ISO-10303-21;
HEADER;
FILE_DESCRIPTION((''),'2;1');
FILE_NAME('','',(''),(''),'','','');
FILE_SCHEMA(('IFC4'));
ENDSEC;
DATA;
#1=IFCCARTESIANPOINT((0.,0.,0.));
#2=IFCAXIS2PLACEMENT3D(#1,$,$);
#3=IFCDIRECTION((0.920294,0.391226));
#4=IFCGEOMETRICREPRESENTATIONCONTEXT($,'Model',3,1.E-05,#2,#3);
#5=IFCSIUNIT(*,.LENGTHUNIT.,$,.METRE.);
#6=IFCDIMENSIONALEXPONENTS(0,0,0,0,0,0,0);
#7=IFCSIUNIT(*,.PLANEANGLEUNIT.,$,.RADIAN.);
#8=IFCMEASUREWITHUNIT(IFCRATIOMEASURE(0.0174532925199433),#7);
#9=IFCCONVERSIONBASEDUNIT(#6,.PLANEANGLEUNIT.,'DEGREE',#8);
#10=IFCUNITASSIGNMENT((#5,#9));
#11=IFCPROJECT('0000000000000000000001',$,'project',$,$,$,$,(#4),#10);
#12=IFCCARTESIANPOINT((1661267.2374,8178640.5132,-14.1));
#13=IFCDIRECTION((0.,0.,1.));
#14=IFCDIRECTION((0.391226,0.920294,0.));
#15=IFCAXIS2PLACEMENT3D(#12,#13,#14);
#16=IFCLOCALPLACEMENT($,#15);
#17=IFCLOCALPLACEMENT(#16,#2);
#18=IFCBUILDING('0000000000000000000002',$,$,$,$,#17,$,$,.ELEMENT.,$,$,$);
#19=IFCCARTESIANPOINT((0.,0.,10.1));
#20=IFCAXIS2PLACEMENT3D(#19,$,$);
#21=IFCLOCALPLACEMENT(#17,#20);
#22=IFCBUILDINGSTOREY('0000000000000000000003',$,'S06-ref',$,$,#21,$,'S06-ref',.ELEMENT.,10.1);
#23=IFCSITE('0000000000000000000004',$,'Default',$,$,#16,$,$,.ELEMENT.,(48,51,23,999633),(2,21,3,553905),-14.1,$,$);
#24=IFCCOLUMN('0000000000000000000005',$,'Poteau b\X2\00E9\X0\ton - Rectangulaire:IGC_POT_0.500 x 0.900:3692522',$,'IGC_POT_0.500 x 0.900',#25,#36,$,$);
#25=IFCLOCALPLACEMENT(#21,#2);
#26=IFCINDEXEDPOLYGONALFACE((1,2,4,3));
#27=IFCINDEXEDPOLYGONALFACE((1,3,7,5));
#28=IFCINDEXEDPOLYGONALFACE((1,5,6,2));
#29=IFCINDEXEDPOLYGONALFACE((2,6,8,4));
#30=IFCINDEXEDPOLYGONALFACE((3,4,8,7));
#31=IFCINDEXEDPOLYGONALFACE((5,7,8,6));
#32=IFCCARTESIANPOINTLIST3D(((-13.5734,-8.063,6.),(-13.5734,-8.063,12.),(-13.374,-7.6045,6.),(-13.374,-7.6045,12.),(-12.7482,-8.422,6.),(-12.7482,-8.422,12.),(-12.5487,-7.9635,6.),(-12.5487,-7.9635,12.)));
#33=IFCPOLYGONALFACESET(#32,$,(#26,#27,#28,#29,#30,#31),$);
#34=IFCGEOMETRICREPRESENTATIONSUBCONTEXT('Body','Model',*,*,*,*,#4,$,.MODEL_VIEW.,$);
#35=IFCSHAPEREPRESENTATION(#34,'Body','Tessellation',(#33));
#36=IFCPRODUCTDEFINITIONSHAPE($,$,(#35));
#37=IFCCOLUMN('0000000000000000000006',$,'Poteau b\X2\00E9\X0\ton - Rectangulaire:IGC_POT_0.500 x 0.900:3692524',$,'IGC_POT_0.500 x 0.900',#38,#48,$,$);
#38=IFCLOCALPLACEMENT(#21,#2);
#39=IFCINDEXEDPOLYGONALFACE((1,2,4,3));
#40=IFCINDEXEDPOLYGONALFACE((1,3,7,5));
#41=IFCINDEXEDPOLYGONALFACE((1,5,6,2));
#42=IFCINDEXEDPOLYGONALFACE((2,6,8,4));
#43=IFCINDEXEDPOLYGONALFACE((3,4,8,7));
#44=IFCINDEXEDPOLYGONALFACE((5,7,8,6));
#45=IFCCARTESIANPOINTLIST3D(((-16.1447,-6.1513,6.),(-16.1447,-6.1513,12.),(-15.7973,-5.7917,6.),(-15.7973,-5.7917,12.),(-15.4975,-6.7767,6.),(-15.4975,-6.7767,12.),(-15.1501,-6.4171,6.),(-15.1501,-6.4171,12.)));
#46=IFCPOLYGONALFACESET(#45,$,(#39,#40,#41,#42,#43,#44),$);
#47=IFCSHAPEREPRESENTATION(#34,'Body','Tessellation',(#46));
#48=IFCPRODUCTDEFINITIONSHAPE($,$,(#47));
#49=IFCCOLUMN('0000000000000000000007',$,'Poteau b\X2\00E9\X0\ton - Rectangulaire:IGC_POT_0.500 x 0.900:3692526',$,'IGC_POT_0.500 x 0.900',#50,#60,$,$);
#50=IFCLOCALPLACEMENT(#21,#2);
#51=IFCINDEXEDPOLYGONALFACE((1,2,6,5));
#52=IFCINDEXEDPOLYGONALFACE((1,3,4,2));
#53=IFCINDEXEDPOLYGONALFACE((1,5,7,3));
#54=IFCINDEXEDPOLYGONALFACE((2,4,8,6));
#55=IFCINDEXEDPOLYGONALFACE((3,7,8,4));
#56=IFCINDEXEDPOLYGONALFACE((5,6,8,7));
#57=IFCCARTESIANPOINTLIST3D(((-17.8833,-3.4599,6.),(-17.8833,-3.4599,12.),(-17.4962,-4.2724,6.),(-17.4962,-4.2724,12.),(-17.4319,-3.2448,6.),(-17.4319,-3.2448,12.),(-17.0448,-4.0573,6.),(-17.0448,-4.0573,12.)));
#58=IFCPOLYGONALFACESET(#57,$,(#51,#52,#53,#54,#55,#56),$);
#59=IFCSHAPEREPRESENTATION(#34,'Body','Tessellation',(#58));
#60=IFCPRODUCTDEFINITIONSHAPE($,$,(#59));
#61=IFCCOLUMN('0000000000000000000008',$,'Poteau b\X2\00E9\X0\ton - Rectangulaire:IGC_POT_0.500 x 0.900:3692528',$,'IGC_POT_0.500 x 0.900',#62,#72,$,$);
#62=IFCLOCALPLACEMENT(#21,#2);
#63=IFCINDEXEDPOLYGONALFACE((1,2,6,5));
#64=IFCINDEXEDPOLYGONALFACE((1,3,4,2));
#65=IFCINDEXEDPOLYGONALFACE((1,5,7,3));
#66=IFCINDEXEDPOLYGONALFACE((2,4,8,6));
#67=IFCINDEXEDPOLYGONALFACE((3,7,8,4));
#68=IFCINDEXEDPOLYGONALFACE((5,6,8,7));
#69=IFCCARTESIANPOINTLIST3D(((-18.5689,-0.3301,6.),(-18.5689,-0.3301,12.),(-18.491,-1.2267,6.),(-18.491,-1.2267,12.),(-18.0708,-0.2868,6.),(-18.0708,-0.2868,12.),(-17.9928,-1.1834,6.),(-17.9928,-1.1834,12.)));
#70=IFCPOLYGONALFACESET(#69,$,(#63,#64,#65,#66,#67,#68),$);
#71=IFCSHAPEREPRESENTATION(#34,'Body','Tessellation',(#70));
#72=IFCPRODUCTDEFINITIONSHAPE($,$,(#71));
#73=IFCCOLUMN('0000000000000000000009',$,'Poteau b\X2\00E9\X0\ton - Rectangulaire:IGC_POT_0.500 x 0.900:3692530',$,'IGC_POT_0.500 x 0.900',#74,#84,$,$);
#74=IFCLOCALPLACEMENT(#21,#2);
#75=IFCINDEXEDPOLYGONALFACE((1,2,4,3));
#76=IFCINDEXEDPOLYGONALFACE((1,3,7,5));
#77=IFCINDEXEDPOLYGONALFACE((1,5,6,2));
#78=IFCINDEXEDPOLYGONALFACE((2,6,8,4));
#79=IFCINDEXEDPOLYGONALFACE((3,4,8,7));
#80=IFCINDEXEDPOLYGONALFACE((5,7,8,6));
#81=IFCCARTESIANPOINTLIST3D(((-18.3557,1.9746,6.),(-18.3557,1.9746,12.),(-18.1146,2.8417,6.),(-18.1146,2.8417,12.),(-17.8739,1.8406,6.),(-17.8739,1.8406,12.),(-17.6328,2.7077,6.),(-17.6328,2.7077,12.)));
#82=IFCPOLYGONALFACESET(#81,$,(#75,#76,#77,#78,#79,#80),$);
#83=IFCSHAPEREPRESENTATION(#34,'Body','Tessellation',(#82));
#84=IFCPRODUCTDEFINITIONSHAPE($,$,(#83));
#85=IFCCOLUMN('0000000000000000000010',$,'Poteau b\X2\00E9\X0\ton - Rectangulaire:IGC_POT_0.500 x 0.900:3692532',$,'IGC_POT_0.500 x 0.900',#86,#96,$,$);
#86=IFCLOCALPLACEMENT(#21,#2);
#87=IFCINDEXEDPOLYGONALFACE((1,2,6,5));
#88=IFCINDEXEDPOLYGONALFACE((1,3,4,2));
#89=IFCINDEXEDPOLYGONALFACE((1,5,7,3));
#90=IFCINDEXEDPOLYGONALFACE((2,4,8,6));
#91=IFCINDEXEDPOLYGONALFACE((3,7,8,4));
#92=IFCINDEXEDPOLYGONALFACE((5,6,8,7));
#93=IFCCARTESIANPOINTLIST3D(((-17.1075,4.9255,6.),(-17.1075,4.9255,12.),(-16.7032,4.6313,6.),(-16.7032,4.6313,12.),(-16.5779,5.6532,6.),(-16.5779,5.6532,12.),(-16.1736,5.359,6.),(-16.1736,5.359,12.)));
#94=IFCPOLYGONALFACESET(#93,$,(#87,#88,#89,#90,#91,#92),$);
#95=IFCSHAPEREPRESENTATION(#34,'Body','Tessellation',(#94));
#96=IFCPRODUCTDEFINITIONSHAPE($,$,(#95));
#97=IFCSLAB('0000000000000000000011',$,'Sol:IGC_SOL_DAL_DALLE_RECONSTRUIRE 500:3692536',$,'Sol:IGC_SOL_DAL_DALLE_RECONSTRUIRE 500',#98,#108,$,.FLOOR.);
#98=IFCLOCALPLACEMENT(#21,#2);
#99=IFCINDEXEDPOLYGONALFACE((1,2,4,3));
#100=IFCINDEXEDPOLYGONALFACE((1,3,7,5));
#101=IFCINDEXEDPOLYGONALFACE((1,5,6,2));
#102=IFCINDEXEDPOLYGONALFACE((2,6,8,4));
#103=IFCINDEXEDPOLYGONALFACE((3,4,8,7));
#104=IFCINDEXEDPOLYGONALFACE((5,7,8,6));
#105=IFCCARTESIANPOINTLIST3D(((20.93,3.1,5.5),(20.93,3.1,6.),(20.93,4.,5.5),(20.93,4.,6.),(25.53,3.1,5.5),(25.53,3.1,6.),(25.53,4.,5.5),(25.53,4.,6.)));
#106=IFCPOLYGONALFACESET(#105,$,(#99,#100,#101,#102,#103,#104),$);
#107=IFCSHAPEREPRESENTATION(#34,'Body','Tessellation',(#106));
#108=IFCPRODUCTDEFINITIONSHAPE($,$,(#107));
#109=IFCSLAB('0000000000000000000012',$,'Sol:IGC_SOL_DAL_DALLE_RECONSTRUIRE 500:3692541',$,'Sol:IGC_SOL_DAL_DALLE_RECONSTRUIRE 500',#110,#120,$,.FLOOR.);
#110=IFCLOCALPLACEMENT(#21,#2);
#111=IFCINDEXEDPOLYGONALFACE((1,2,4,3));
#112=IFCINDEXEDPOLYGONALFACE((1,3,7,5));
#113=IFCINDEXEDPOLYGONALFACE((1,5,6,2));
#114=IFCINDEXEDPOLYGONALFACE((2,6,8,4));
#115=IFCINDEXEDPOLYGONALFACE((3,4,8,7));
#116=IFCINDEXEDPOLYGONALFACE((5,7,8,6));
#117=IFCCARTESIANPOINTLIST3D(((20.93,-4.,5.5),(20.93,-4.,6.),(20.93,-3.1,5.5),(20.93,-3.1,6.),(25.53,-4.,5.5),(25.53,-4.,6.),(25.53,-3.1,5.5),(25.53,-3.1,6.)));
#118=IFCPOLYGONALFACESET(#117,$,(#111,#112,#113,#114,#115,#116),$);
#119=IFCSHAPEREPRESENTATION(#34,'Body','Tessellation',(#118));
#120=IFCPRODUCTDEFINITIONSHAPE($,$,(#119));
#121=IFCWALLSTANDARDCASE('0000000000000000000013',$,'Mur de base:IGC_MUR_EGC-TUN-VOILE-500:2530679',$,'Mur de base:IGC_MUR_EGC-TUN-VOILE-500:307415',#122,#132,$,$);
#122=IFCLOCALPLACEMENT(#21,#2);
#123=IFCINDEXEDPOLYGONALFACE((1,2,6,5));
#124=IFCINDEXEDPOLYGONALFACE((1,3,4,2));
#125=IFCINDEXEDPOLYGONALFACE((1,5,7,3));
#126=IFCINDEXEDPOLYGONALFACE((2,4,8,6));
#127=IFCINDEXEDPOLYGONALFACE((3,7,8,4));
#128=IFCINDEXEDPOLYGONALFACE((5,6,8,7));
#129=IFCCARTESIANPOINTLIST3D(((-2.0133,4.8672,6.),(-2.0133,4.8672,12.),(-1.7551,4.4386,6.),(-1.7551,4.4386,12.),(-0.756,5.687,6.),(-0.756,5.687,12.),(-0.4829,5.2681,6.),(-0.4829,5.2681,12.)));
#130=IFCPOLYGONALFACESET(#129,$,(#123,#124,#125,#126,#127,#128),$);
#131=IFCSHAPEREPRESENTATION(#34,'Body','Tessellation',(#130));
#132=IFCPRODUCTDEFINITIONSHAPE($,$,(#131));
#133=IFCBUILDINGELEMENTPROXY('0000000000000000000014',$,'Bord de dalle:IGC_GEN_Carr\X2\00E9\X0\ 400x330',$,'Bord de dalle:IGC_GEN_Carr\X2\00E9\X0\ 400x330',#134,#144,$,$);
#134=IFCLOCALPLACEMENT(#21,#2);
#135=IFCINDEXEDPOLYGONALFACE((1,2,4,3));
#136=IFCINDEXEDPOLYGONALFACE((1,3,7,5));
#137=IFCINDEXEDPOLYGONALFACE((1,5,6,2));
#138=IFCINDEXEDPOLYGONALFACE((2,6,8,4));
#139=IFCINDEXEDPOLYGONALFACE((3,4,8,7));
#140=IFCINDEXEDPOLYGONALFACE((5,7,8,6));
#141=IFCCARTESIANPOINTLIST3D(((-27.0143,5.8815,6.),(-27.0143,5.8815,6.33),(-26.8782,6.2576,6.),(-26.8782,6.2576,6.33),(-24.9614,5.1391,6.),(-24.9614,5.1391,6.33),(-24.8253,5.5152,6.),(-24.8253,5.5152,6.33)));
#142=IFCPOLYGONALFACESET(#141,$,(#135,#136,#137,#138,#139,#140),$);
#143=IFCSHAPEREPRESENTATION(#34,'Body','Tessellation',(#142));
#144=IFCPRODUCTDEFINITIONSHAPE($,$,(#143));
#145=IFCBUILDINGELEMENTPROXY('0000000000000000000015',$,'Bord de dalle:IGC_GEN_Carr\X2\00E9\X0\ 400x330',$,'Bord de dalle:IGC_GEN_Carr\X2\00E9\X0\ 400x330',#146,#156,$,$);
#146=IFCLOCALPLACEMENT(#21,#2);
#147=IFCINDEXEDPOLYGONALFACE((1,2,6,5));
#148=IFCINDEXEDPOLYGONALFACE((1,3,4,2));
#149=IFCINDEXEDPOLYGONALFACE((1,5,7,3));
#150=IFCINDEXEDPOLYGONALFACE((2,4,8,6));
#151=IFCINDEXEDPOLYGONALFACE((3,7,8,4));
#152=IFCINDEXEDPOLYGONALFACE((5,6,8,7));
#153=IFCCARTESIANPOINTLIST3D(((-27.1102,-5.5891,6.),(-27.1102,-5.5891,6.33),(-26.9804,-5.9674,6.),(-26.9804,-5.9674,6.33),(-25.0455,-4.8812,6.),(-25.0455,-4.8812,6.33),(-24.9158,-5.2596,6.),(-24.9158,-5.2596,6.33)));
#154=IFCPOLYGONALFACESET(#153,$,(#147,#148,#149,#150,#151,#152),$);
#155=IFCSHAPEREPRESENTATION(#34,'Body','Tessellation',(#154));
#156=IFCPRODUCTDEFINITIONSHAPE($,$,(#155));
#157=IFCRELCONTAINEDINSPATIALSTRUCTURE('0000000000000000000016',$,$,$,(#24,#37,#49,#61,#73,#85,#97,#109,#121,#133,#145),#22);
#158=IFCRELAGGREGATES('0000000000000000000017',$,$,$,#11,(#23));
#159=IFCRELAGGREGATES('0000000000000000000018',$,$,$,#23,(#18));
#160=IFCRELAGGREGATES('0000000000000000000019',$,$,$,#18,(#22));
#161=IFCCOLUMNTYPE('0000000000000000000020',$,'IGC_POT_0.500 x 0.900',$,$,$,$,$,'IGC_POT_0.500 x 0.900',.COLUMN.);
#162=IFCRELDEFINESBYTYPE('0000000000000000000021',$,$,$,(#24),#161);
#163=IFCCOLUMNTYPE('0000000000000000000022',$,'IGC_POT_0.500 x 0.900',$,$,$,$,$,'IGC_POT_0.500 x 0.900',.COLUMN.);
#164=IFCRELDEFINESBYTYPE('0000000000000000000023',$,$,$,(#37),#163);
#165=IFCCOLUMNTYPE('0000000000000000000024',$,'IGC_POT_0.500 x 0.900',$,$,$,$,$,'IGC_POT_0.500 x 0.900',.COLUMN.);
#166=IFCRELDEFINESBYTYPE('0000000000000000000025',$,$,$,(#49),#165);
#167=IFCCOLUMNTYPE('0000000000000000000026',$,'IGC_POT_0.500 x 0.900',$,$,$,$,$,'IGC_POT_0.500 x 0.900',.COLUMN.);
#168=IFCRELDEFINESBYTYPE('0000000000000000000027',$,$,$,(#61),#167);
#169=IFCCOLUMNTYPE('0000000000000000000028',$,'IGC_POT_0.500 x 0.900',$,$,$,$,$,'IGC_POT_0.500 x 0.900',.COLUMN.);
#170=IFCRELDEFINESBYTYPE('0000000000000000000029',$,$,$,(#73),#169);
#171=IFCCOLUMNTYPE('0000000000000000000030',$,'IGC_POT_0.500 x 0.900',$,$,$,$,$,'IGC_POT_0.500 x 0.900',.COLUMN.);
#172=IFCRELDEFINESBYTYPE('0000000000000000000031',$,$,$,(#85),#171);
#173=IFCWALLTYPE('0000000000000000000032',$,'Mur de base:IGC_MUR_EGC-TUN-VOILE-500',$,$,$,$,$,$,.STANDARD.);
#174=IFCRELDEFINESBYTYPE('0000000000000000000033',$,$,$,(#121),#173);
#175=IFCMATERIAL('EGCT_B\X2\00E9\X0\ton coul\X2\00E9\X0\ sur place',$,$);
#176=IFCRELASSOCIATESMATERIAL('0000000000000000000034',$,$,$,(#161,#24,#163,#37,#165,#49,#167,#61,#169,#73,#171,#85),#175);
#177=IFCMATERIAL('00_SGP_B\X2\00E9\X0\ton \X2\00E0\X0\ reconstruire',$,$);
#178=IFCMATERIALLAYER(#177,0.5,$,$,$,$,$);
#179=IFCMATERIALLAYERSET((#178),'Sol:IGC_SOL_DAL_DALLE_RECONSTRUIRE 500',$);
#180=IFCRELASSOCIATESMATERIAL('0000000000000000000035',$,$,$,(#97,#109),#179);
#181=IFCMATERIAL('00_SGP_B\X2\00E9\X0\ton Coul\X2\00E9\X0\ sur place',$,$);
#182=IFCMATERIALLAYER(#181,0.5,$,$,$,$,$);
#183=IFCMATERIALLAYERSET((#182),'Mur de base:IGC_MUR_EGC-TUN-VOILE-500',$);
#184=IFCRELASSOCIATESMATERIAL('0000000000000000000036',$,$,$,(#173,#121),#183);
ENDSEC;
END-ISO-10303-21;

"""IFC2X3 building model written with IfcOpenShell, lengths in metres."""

from ifc_helpers import new_model, entity, si_unit, converted_unit, direction, frame, frame_2d, origin, origin_2d_with_axis, place, context, subcontext, project, spatial, polyline, rectangle, extrude, clip, bounded_halfspace, source, transform, mapped, material, layer, layer_set, layer_usage, type_object, type_shapes, element, save


model = new_model("IFC2X3")

# Units and contexts
model_context = context("Model", 3, precision=1e-05, world=origin(), true_north=direction((0.920294, 0.391226)))
body_context = subcontext(model_context, "Body", "Model", "MODEL_VIEW")
ifc_project = project(units=[si_unit("LENGTHUNIT", "METRE"), converted_unit("PLANEANGLEUNIT", "DEGREE", entity("IfcRatioMeasure", 0.0174532925199433), si_unit("PLANEANGLEUNIT", "RADIAN"), dimensions=[0, 0, 0, 0, 0, 0, 0])], contexts=[model_context])

# Site, building, storey
site_placement = place(None, frame((1661267.2374, 8178640.5132, -14.1), z_axis=(0.0, 0.0, 1.0), x_axis=(0.391226, 0.920294, 0.0)))
site = spatial("IfcSite", under=ifc_project, at=site_placement, Name="Default", CompositionType="ELEMENT", RefLatitude=(48, 51, 23, 999633), RefLongitude=(2, 21, 3, 553905), RefElevation=-14.1)
building_placement = place(site_placement, origin())
building = spatial("IfcBuilding", under=site, at=building_placement, CompositionType="ELEMENT")
storey_placement = place(building_placement, frame((0.0, 0.0, 10.1)))
storey = spatial("IfcBuildingStorey", under=building, at=storey_placement, Name="S06-ref", LongName="S06-ref", CompositionType="ELEMENT", Elevation=10.1)

# Columns
ifc_material_1 = material(Name="EGCT_Béton coulé sur place")
column_type_1 = type_object("IfcColumnType", Name="IGC_POT_0.500 x 0.900", ElementType="IGC_POT_0.500 x 0.900", PredefinedType="COLUMN", material=ifc_material_1)
shared_shape_1 = source(origin(), body_context, "Body", "SweptSolid", [
    extrude(rectangle(XDim=0.9, YDim=0.5, at=frame_2d((0.0, 0.0), x_axis=(1.0, 0.0))), frame((-13.0611, -8.0132, 16.1), z_axis=(0.0, 0.0, 1.0), x_axis=(-0.916984, 0.398923, 0.0)), (0.0, 0.0, 1.0), 6.0),
])
type_shapes(column_type_1, [shared_shape_1])
column_1_placement = place(storey_placement, frame((0.0, 0.0, -10.1)))
element("IfcColumn", 1, at=column_1_placement, inside=storey, type_object=column_type_1, material=ifc_material_1, Name="Poteau béton - Rectangulaire:IGC_POT_0.500 x 0.900:3692522", ObjectType="IGC_POT_0.500 x 0.900", context=body_context, shape_type="MappedRepresentation", body=[
    mapped(shared_shape_1, transform((0.0, 0.0, 0.0), scale=1.0)),
])
column_type_2 = type_object("IfcColumnType", Name="IGC_POT_0.500 x 0.900", ElementType="IGC_POT_0.500 x 0.900", PredefinedType="COLUMN", material=ifc_material_1)
shared_shape_2 = source(origin(), body_context, "Body", "SweptSolid", [
    extrude(rectangle(XDim=0.9, YDim=0.5, at=origin_2d_with_axis()), frame((-15.6474, -6.2842, 16.1), z_axis=(0.0, 0.0, 1.0), x_axis=(-0.719121, 0.694885, 0.0)), (0.0, 0.0, 1.0), 6.0),
])
type_shapes(column_type_2, [shared_shape_2])
column_2_placement = place(storey_placement, frame((0.0, 0.0, -10.1)))
element("IfcColumn", 2, at=column_2_placement, inside=storey, type_object=column_type_2, material=ifc_material_1, Name="Poteau béton - Rectangulaire:IGC_POT_0.500 x 0.900:3692524", ObjectType="IGC_POT_0.500 x 0.900", context=body_context, shape_type="MappedRepresentation", body=[
    mapped(shared_shape_2, transform((0.0, 0.0, 0.0), scale=1.0)),
])
column_type_3 = type_object("IfcColumnType", Name="IGC_POT_0.500 x 0.900", ElementType="IGC_POT_0.500 x 0.900", PredefinedType="COLUMN", material=ifc_material_1)
shared_shape_3 = source(origin(), body_context, "Body", "SweptSolid", [
    extrude(rectangle(XDim=0.9, YDim=0.5, at=frame_2d((0.0, 0.0), x_axis=(1.0, 0.0))), frame((-17.4641, -3.7586, 16.1), z_axis=(0.0, 0.0, 1.0), x_axis=(-0.430108, 0.902777, 0.0)), (0.0, 0.0, 1.0), 6.0),
])
type_shapes(column_type_3, [shared_shape_3])
column_3_placement = place(storey_placement, frame((0.0, 0.0, -10.1)))
element("IfcColumn", 3, at=column_3_placement, inside=storey, type_object=column_type_3, material=ifc_material_1, Name="Poteau béton - Rectangulaire:IGC_POT_0.500 x 0.900:3692526", ObjectType="IGC_POT_0.500 x 0.900", context=body_context, shape_type="MappedRepresentation", body=[
    mapped(shared_shape_3, transform((0.0, 0.0, 0.0), scale=1.0)),
])
column_type_4 = type_object("IfcColumnType", Name="IGC_POT_0.500 x 0.900", ElementType="IGC_POT_0.500 x 0.900", PredefinedType="COLUMN", material=ifc_material_1)
shared_shape_4 = source(origin(), body_context, "Body", "SweptSolid", [
    extrude(rectangle(XDim=0.9, YDim=0.5, at=frame_2d((0.0, 0.0), x_axis=(1.0, 0.0))), frame((-18.2809, -0.7567, 16.1), z_axis=(0.0, 0.0, 1.0), x_axis=(-0.086594, 0.996244, 0.0)), (0.0, 0.0, 1.0), 6.0),
])
type_shapes(column_type_4, [shared_shape_4])
column_4_placement = place(storey_placement, frame((0.0, 0.0, -10.1)))
element("IfcColumn", 4, at=column_4_placement, inside=storey, type_object=column_type_4, material=ifc_material_1, Name="Poteau béton - Rectangulaire:IGC_POT_0.500 x 0.900:3692528", ObjectType="IGC_POT_0.500 x 0.900", context=body_context, shape_type="MappedRepresentation", body=[
    mapped(shared_shape_4, transform((0.0, 0.0, 0.0), scale=1.0)),
])
column_type_5 = type_object("IfcColumnType", Name="IGC_POT_0.500 x 0.900", ElementType="IGC_POT_0.500 x 0.900", PredefinedType="COLUMN", material=ifc_material_1)
shared_shape_5 = source(origin(), body_context, "Body", "SweptSolid", [
    extrude(rectangle(XDim=0.5, YDim=0.9, at=frame_2d((0.0, 0.0), x_axis=(1.0, 0.0))), frame((-17.9943, 2.3411, 16.1), z_axis=(0.0, 0.0, 1.0), x_axis=(-0.963446, 0.267904, 0.0)), (0.0, 0.0, 1.0), 6.0),
])
type_shapes(column_type_5, [shared_shape_5])
column_5_placement = place(storey_placement, frame((0.0, 0.0, -10.1)))
element("IfcColumn", 5, at=column_5_placement, inside=storey, type_object=column_type_5, material=ifc_material_1, Name="Poteau béton - Rectangulaire:IGC_POT_0.500 x 0.900:3692530", ObjectType="IGC_POT_0.500 x 0.900", context=body_context, shape_type="MappedRepresentation", body=[
    mapped(shared_shape_5, transform((0.0, 0.0, 0.0), scale=1.0)),
])
column_type_6 = type_object("IfcColumnType", Name="IGC_POT_0.500 x 0.900", ElementType="IGC_POT_0.500 x 0.900", PredefinedType="COLUMN", material=ifc_material_1)
shared_shape_6 = source(origin(), body_context, "Body", "SweptSolid", [
    extrude(rectangle(XDim=0.5, YDim=0.9, at=frame_2d((0.0, 0.0), x_axis=(1.0, 0.0))), frame((-16.6405, 5.1423, 16.1), z_axis=(0.0, 0.0, 1.0), x_axis=(-0.808536, 0.588447, 0.0)), (0.0, 0.0, 1.0), 6.0),
])
type_shapes(column_type_6, [shared_shape_6])
column_6_placement = place(storey_placement, frame((0.0, 0.0, -10.1)))
element("IfcColumn", 6, at=column_6_placement, inside=storey, type_object=column_type_6, material=ifc_material_1, Name="Poteau béton - Rectangulaire:IGC_POT_0.500 x 0.900:3692532", ObjectType="IGC_POT_0.500 x 0.900", context=body_context, shape_type="MappedRepresentation", body=[
    mapped(shared_shape_6, transform((0.0, 0.0, 0.0), scale=1.0)),
])

# Slabs
ifc_material_2 = material(Name="00_SGP_Béton à reconstruire")
ifc_layer_1 = layer(ifc_material_2, 0.5)
ifc_layer_set_1 = layer_set([ifc_layer_1], Name="Sol:IGC_SOL_DAL_DALLE_RECONSTRUIRE 500")
ifc_layer_usage_1 = layer_usage(ifc_layer_set_1, "AXIS3", "POSITIVE", 0.0)
slab_1_placement = place(storey_placement, origin())
element("IfcSlab", 7, at=slab_1_placement, inside=storey, material=ifc_layer_usage_1, Name="Sol:IGC_SOL_DAL_DALLE_RECONSTRUIRE 500:3692536", ObjectType="Sol:IGC_SOL_DAL_DALLE_RECONSTRUIRE 500", PredefinedType="FLOOR", context=body_context, shape_type="SweptSolid", body=[
    extrude(rectangle(XDim=0.9, YDim=4.6, at=frame_2d((0.0, 0.0), x_axis=(1.0, 0.0))), frame((23.23, 3.55, 6.0), z_axis=(0.0, 0.0, -1.0), x_axis=(0.0, 1.0, 0.0)), (0.0, 0.0, 1.0), 0.5),
])
ifc_layer_usage_2 = layer_usage(ifc_layer_set_1, "AXIS3", "POSITIVE", 0.0)
slab_2_placement = place(storey_placement, origin())
element("IfcSlab", 8, at=slab_2_placement, inside=storey, material=ifc_layer_usage_2, Name="Sol:IGC_SOL_DAL_DALLE_RECONSTRUIRE 500:3692541", ObjectType="Sol:IGC_SOL_DAL_DALLE_RECONSTRUIRE 500", PredefinedType="FLOOR", context=body_context, shape_type="SweptSolid", body=[
    extrude(rectangle(XDim=0.9, YDim=4.6, at=frame_2d((0.0, 0.0), x_axis=(1.0, 0.0))), frame((23.23, -3.55, 6.0), z_axis=(0.0, 0.0, -1.0), x_axis=(0.0, 1.0, 0.0)), (0.0, 0.0, 1.0), 0.5),
])
ifc_material_3 = material(Name="00_SGP_Béton Coulé sur place")

# Wall
ifc_layer_2 = layer(ifc_material_3, 0.5)
ifc_layer_set_2 = layer_set([ifc_layer_2], Name="Mur de base:IGC_MUR_EGC-TUN-VOILE-500")
wall_type = type_object("IfcWallType", Name="Mur de base:IGC_MUR_EGC-TUN-VOILE-500", PredefinedType="STANDARD", material=ifc_layer_set_2)
ifc_layer_usage_3 = layer_usage(ifc_layer_set_2, "AXIS2", "NEGATIVE", 0.25)
wall_1_placement = place(storey_placement, frame((-0.6194, 5.4776, 6.0), z_axis=(0.0, 0.0, 1.0), x_axis=(-0.837671, -0.546175, 0.0)))
element("IfcWallStandardCase", 9, at=wall_1_placement, inside=storey, type_object=wall_type, material=ifc_layer_usage_3, Name="Mur de base:IGC_MUR_EGC-TUN-VOILE-500:2530679", ObjectType="Mur de base:IGC_MUR_EGC-TUN-VOILE-500:307415", context=body_context, shape_type="Clipping", body=[
    clip(extrude(rectangle(XDim=1.5187, YDim=0.5, at=frame_2d((0.7594, 0.0), x_axis=(-1.0, 0.0))), origin(), (0.0, 0.0, 1.0), 6.0), bounded_halfspace(frame((1.501, -0.25, 6.0), z_axis=(-0.999368, 0.035559, 0.0), x_axis=(0.0, 0.0, -1.0)), True, frame((1.501, -0.25, 6.0), z_axis=(-0.999368, 0.035559, 0.0), x_axis=(0.0, 0.0, -1.0)), polyline([(0.0, 0.0), (0.0, -0.5003), (6.0, -0.5003), (6.0, 0.0), (0.0, 0.0)]))),
])

# Building element proxies
proxy_1_placement = place(storey_placement, origin())
element("IfcBuildingElementProxy", 10, at=proxy_1_placement, inside=storey, Name="Bord de dalle:IGC_GEN_Carré 400x330", ObjectType="Bord de dalle:IGC_GEN_Carré 400x330", context=body_context, shape_type="SweptSolid", body=[
    extrude(rectangle(XDim=2.1831, YDim=0.4, at=frame_2d((0.0, 0.0), x_axis=(1.0, 0.0))), frame((-25.9198, 5.6984, 6.0), z_axis=(0.0, 0.0, 1.0), x_axis=(-0.940394, 0.340087, 0.0)), (0.0, 0.0, 1.0), 0.33),
])
proxy_2_placement = place(storey_placement, origin())
element("IfcBuildingElementProxy", 11, at=proxy_2_placement, inside=storey, Name="Bord de dalle:IGC_GEN_Carré 400x330", ObjectType="Bord de dalle:IGC_GEN_Carré 400x330", context=body_context, shape_type="SweptSolid", body=[
    extrude(rectangle(XDim=2.1827, YDim=0.4, at=frame_2d((0.0, 0.0), x_axis=(1.0, 0.0))), frame((-26.013, -5.4243, 6.0), z_axis=(0.0, 0.0, 1.0), x_axis=(0.945947, 0.324321, 0.0)), (0.0, 0.0, 1.0), 0.33),
])

save(model, "model.ifc")
